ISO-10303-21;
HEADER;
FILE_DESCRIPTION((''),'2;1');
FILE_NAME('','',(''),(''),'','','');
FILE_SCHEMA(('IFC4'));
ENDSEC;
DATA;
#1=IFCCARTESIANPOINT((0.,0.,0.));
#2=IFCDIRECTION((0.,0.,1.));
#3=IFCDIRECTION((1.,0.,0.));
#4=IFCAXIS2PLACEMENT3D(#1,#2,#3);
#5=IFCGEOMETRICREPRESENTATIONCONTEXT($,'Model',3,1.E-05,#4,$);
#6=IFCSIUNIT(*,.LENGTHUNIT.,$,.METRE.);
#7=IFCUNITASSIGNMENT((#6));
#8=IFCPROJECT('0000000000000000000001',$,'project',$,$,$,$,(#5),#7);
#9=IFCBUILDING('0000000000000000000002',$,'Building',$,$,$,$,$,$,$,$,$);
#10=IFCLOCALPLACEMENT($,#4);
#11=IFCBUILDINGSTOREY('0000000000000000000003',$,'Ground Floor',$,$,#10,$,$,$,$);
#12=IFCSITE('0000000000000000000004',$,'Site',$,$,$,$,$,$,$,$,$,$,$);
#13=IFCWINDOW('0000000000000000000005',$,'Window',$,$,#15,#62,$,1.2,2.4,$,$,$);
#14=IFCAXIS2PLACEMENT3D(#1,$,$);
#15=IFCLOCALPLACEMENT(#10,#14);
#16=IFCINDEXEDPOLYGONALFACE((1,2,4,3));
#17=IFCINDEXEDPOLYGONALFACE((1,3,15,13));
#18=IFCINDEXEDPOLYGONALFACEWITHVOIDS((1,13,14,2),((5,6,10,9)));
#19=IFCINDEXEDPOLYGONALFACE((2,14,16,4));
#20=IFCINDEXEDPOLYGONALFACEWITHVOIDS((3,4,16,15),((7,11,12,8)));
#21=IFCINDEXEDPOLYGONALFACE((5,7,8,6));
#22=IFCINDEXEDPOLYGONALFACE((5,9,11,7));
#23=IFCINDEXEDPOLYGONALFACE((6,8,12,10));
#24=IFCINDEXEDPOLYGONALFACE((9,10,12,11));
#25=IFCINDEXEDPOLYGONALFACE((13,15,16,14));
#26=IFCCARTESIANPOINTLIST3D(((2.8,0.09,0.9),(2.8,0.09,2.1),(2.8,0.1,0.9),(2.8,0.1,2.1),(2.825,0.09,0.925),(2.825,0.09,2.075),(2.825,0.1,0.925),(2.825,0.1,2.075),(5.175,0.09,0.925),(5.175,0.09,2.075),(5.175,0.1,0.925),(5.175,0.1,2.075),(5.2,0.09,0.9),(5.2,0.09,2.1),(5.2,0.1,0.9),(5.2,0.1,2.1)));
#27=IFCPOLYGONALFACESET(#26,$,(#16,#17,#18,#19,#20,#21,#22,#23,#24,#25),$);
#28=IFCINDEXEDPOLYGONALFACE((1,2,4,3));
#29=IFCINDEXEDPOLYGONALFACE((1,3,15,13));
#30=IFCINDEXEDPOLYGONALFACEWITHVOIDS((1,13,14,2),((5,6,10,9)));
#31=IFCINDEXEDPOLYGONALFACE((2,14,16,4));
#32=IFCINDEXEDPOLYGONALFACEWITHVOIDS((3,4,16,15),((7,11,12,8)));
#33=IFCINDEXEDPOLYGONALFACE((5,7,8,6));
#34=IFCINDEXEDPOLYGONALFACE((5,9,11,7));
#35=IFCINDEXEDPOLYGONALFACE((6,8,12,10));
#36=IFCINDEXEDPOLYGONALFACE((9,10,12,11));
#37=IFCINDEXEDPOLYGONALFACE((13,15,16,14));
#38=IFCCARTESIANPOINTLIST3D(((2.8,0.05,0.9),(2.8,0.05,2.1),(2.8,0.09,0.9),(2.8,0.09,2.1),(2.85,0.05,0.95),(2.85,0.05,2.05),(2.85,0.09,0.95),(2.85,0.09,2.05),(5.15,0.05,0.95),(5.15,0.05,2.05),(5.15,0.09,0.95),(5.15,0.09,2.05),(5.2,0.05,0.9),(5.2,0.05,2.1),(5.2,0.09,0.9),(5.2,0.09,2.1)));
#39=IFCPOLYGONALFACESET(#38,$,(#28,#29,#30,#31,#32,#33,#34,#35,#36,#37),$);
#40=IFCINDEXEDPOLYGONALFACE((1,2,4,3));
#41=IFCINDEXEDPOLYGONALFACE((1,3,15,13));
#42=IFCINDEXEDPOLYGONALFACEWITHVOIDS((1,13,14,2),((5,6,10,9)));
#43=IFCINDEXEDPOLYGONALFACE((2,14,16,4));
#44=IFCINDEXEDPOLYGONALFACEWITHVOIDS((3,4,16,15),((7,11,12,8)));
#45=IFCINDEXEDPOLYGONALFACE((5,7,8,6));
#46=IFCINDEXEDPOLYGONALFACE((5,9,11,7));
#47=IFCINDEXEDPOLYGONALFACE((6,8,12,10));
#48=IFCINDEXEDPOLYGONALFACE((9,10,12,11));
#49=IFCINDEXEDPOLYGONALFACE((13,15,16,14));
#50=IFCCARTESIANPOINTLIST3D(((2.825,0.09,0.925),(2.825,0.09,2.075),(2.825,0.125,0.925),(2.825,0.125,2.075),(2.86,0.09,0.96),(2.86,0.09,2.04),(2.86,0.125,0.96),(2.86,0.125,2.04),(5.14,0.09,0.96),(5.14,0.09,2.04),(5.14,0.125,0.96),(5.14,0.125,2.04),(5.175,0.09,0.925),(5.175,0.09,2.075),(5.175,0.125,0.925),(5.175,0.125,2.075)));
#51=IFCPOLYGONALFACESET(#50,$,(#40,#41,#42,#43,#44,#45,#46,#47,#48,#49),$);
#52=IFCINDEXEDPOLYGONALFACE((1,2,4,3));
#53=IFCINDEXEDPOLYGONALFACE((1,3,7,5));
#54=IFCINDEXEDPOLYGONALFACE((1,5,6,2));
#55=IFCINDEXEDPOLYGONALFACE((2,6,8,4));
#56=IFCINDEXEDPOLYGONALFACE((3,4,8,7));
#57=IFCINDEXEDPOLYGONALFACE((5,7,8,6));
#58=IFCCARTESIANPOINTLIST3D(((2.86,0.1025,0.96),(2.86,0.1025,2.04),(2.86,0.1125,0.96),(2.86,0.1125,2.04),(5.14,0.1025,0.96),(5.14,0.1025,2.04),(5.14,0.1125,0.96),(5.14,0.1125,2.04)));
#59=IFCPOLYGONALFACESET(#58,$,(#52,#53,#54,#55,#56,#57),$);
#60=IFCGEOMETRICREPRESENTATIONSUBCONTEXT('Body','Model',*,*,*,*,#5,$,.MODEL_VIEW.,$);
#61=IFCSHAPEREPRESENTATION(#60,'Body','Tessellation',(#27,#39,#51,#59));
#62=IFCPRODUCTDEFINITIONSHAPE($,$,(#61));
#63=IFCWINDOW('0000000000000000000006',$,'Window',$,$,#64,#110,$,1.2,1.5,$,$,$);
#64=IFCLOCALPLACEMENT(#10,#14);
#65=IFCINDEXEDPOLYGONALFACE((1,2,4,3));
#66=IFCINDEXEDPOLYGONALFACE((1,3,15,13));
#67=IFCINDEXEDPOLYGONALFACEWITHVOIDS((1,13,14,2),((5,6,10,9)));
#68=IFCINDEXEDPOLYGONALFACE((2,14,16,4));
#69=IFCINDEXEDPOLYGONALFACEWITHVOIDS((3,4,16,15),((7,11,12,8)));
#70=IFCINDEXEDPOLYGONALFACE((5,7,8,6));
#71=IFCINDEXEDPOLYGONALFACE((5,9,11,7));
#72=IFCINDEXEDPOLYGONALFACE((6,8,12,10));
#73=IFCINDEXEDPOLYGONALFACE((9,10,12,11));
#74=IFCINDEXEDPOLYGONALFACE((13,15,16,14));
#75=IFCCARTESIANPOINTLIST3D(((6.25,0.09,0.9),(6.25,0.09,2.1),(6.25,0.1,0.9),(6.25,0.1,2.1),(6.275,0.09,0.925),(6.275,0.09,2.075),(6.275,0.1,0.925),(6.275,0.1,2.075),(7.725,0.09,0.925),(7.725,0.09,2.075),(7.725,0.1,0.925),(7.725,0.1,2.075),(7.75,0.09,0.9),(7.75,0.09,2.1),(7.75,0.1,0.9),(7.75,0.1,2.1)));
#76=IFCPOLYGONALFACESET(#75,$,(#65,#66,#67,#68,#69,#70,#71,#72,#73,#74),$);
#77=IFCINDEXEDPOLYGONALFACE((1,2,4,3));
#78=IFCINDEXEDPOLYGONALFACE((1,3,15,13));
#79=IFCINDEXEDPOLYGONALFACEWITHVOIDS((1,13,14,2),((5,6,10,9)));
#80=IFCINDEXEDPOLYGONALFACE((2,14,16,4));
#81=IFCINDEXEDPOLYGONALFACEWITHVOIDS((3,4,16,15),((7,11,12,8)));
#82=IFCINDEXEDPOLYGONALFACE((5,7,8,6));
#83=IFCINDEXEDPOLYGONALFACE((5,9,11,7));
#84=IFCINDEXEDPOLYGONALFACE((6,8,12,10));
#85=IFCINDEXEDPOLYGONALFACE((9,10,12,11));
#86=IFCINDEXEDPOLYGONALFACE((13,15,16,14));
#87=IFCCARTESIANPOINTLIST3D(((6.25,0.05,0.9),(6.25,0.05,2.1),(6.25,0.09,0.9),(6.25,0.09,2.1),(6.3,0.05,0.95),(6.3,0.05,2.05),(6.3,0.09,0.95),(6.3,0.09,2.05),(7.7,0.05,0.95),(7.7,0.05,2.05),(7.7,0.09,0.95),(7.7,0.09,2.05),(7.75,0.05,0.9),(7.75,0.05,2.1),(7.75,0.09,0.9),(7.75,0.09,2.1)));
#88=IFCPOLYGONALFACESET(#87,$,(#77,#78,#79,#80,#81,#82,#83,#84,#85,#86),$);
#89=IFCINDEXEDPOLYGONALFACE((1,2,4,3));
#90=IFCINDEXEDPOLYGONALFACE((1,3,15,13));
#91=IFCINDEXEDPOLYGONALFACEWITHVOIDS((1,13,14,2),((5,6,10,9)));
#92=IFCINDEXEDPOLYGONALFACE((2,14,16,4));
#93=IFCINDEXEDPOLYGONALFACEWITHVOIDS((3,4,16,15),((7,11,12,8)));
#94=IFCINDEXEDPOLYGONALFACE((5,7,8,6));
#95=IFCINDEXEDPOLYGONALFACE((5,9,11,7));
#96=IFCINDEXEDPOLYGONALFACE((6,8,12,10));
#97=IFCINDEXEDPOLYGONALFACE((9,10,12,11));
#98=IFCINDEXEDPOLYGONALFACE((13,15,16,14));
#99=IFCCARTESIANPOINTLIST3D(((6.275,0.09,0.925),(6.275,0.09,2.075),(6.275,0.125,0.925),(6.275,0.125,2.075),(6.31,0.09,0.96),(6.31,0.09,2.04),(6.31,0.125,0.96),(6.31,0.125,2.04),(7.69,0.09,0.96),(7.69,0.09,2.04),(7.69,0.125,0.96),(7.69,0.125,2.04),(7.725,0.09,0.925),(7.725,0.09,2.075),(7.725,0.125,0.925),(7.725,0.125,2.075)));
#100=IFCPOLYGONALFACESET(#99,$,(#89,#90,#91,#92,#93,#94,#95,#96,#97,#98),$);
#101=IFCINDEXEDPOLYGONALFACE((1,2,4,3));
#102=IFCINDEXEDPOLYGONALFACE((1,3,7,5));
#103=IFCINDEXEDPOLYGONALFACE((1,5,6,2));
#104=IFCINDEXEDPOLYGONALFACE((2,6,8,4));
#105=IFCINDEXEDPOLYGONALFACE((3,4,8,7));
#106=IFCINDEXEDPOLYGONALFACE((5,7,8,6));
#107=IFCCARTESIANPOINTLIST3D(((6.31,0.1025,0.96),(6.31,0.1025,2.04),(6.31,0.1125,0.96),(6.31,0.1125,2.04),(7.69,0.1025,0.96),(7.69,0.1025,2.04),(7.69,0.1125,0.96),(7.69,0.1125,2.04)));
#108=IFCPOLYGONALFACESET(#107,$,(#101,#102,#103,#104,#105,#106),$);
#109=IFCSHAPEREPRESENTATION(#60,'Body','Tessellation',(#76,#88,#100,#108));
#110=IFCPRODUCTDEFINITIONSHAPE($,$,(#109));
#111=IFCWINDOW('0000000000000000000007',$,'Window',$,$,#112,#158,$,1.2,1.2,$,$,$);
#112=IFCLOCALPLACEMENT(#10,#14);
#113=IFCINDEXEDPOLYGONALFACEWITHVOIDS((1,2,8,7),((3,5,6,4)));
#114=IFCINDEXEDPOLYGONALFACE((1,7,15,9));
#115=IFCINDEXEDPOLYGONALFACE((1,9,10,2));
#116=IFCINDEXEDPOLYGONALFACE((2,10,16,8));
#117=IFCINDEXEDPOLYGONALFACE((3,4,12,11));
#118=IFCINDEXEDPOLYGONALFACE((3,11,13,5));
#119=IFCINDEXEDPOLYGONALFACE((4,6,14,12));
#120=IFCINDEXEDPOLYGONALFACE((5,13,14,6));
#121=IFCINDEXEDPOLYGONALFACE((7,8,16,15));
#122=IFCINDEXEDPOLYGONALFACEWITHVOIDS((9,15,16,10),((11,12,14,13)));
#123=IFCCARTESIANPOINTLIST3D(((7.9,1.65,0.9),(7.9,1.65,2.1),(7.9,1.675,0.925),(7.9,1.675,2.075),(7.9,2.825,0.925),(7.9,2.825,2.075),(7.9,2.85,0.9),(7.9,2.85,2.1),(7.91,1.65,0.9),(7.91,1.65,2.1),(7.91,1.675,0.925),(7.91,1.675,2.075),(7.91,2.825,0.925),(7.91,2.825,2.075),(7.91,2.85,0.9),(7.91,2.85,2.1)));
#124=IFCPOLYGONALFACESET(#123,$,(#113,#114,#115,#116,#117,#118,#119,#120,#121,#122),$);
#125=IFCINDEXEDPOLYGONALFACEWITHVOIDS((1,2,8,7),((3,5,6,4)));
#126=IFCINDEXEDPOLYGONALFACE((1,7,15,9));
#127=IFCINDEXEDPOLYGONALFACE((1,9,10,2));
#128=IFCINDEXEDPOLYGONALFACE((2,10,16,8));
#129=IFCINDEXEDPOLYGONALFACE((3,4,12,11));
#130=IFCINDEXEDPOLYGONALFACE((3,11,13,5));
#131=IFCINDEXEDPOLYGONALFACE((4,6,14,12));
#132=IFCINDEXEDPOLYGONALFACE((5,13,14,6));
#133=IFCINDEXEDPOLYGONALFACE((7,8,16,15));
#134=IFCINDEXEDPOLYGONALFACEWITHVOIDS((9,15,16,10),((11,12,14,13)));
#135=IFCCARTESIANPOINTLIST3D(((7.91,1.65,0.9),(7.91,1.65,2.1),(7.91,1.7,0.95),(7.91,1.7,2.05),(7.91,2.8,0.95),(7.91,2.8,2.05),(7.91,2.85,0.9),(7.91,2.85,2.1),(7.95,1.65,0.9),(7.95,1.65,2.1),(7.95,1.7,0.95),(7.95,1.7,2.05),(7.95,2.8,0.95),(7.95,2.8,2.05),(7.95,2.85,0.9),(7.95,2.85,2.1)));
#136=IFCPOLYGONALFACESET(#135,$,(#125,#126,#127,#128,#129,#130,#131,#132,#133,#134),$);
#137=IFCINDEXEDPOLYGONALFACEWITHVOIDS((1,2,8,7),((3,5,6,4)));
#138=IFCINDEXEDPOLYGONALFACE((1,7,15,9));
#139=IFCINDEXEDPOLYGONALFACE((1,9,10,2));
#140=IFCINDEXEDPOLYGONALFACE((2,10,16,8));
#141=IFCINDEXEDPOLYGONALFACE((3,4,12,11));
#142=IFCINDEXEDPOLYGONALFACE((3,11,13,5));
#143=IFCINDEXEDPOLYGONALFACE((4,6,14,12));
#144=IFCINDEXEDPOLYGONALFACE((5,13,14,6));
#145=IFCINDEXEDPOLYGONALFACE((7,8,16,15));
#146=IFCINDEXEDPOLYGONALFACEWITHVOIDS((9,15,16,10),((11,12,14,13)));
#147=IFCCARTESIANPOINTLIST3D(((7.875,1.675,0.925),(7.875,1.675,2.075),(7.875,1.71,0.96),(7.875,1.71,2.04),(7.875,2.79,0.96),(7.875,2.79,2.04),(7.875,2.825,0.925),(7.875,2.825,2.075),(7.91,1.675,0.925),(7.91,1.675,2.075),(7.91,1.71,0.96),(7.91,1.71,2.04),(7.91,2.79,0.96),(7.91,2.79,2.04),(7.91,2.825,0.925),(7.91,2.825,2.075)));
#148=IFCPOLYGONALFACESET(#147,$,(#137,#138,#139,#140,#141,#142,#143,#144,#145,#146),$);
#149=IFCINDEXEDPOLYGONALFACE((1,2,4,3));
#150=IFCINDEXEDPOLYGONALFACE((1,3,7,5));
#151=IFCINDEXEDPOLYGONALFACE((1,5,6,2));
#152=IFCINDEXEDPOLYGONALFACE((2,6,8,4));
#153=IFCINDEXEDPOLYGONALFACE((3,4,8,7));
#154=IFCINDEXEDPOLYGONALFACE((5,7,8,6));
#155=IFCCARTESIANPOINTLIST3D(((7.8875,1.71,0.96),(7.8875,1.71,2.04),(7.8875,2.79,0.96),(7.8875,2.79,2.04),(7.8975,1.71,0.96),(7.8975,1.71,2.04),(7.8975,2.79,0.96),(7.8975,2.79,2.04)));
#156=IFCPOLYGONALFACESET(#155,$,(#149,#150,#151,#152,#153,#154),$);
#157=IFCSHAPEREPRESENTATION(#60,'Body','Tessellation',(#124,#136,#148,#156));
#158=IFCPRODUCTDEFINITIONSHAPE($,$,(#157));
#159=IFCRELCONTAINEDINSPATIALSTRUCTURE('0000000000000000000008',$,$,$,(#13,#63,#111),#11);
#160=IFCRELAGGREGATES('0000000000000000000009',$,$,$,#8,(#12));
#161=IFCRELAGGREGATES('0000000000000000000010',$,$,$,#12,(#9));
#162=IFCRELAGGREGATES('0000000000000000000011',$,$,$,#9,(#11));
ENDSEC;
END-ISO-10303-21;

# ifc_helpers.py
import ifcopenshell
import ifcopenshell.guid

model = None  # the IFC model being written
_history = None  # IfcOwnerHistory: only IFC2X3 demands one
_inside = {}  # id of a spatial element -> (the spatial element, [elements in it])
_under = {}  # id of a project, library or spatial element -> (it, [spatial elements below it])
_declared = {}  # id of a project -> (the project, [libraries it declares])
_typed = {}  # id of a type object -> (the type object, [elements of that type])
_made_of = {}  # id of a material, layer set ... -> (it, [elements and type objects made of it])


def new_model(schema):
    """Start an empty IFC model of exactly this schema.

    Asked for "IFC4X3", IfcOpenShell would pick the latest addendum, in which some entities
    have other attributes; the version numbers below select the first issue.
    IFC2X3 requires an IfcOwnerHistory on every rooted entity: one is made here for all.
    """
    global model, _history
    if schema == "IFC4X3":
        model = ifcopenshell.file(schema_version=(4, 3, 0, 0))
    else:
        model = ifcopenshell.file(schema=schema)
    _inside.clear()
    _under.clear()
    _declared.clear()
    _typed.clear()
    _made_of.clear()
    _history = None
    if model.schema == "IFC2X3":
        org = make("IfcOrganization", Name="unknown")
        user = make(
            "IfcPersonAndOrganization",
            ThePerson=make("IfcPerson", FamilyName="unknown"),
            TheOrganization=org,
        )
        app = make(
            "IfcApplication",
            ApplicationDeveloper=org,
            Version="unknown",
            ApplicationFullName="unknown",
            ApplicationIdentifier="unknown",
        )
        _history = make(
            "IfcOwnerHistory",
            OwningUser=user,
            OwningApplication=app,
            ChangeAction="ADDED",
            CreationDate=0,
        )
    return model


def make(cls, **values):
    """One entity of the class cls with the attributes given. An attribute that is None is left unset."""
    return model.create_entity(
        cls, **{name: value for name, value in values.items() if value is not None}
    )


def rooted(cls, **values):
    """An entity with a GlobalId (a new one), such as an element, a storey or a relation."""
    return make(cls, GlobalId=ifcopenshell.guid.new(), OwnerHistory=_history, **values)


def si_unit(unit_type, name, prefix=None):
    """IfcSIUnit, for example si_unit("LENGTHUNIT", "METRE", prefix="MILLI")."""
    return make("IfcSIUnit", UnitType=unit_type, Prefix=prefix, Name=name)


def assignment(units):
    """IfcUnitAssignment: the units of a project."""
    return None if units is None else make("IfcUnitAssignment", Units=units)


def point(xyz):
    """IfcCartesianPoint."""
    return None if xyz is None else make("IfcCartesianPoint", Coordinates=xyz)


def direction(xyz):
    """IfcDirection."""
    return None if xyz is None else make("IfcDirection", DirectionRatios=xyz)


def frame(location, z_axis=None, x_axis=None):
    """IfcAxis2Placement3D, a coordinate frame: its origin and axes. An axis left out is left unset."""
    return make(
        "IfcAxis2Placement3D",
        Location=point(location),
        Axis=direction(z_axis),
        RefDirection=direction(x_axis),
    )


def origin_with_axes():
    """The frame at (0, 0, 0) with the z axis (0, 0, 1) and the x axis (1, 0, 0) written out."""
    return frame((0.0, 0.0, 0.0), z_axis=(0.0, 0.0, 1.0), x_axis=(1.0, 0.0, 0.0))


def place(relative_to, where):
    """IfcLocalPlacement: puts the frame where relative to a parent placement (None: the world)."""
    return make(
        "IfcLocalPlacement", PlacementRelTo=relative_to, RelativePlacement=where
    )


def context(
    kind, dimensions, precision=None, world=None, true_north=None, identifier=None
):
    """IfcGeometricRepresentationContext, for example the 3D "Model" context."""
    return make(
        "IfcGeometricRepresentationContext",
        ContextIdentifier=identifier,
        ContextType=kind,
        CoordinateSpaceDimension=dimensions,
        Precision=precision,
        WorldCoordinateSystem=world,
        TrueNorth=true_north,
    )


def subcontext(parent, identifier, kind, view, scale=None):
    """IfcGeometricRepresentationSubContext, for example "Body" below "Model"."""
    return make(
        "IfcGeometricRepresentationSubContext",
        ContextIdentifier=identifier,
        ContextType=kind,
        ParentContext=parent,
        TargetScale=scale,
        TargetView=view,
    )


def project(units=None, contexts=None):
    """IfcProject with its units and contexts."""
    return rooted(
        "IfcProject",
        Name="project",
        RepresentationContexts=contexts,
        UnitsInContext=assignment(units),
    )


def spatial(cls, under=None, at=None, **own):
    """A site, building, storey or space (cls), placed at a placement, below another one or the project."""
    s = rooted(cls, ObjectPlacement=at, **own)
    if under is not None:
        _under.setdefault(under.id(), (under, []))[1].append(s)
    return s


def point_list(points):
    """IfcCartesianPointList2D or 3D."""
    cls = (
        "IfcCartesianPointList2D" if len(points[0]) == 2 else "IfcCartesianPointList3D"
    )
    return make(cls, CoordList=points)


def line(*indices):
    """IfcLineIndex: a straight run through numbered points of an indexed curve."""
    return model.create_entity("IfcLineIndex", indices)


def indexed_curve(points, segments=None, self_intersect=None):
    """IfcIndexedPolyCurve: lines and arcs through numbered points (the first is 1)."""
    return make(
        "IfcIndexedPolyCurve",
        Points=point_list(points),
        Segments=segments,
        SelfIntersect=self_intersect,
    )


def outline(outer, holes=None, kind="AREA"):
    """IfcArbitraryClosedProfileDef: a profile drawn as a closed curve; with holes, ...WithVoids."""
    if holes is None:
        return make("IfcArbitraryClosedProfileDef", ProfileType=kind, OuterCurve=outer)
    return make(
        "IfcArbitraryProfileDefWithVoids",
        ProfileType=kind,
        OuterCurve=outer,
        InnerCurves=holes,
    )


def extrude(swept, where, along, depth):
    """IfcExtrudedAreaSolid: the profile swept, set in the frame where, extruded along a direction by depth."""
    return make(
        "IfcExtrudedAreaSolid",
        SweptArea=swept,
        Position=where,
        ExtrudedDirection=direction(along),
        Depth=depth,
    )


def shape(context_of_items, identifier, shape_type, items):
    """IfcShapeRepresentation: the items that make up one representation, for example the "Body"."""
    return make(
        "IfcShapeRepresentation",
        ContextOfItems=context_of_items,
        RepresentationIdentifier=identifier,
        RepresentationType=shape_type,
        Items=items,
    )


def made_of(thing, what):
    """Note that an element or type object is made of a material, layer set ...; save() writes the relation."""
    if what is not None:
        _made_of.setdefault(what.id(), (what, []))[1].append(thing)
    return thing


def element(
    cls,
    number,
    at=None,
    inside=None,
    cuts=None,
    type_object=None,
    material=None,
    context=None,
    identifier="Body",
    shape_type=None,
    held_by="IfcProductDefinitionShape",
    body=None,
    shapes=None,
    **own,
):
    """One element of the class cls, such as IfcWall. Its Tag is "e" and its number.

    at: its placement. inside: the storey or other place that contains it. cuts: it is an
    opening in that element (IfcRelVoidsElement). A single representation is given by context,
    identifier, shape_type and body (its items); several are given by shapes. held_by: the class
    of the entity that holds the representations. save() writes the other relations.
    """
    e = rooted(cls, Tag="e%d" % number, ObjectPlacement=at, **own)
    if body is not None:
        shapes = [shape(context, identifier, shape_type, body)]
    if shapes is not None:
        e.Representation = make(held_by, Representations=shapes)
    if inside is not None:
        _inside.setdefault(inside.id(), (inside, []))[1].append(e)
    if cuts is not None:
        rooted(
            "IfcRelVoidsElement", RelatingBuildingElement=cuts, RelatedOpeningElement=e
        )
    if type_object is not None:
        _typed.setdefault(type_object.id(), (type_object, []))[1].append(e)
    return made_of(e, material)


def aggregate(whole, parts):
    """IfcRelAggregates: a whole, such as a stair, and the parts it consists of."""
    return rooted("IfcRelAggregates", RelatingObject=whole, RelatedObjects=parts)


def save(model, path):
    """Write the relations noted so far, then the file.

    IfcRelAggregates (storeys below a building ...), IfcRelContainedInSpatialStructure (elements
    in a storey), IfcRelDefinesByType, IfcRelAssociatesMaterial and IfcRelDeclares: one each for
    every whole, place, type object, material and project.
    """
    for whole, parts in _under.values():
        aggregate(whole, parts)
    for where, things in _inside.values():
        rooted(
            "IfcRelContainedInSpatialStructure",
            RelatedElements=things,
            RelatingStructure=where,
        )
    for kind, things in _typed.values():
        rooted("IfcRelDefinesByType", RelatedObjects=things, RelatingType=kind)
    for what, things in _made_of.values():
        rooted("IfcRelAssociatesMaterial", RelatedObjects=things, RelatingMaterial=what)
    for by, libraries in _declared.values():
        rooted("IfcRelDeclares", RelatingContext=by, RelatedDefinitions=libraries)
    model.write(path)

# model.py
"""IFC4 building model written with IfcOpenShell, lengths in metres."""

from ifc_helpers import new_model, si_unit, frame, origin_with_axes, place, context, subcontext, project, spatial, line, indexed_curve, outline, extrude, element, save


model = new_model("IFC4")

# Units and contexts
model_context = context("Model", 3, precision=1e-05, world=origin_with_axes())
body_context = subcontext(model_context, "Body", "Model", "MODEL_VIEW")
ifc_project = project(units=[si_unit("LENGTHUNIT", "METRE")], contexts=[model_context])

# Site, building, storey
site = spatial("IfcSite", under=ifc_project, Name="Site")
building = spatial("IfcBuilding", under=site, Name="Building")
storey_placement = place(None, origin_with_axes())
storey = spatial("IfcBuildingStorey", under=building, at=storey_placement, Name="Ground Floor")

# Windows
window_1_placement = place(storey_placement, frame((2.8, 0.0, 0.9), z_axis=(0.0, 0.0, 1.0), x_axis=(1.0, 0.0, 0.0)))
element("IfcWindow", 1, at=window_1_placement, inside=storey, Name="Window", OverallHeight=1.2, OverallWidth=2.4, context=body_context, shape_type="SweptSolid", body=[
    extrude(outline(indexed_curve([(0.0, 0.0), (2.4, 0.0), (2.4, 1.2), (0.0, 1.2)], segments=[line(1, 2, 3, 4, 1)]), holes=[indexed_curve([(0.025, 0.025), (2.375, 0.025), (2.375, 1.175), (0.025, 1.175)], segments=[line(1, 2, 3, 4, 1)])]), frame((0.0, 0.09, 0.0), z_axis=(0.0, -1.0, 0.0), x_axis=(1.0, 0.0, 0.0)), (0.0, 0.0, -1.0), 0.01),
    extrude(outline(indexed_curve([(0.0, 0.0), (2.4, 0.0), (2.4, 1.2), (0.0, 1.2)], segments=[line(1, 2, 3, 4, 1)]), holes=[indexed_curve([(0.05, 0.05), (2.35, 0.05), (2.35, 1.15), (0.05, 1.15)], segments=[line(1, 2, 3, 4, 1)])]), frame((0.0, 0.05, 0.0), z_axis=(0.0, -1.0, 0.0), x_axis=(1.0, 0.0, 0.0)), (0.0, 0.0, -1.0), 0.04),
    extrude(outline(indexed_curve([(0.0, 0.0), (2.35, 0.0), (2.35, 1.15), (0.0, 1.15)], segments=[line(1, 2, 3, 4, 1)]), holes=[indexed_curve([(0.035, 0.035), (2.315, 0.035), (2.315, 1.115), (0.035, 1.115)], segments=[line(1, 2, 3, 4, 1)])]), frame((0.025, 0.09, 0.025), z_axis=(0.0, -1.0, 0.0), x_axis=(1.0, 0.0, 0.0)), (0.0, 0.0, -1.0), 0.035),
    extrude(outline(indexed_curve([(0.035, 0.035), (2.315, 0.035), (2.315, 1.115), (0.035, 1.115)], segments=[line(1, 2, 3, 4, 1)])), frame((0.025, 0.1025, 0.025), z_axis=(0.0, -1.0, 0.0), x_axis=(1.0, 0.0, 0.0)), (0.0, 0.0, -1.0), 0.01),
])
window_2_placement = place(storey_placement, frame((6.25, 0.0, 0.9), z_axis=(0.0, 0.0, 1.0), x_axis=(1.0, 0.0, 0.0)))
element("IfcWindow", 2, at=window_2_placement, inside=storey, Name="Window", OverallHeight=1.2, OverallWidth=1.5, context=body_context, shape_type="SweptSolid", body=[
    extrude(outline(indexed_curve([(0.0, 0.0), (1.5, 0.0), (1.5, 1.2), (0.0, 1.2)], segments=[line(1, 2, 3, 4, 1)]), holes=[indexed_curve([(0.025, 0.025), (1.475, 0.025), (1.475, 1.175), (0.025, 1.175)], segments=[line(1, 2, 3, 4, 1)])]), frame((0.0, 0.09, 0.0), z_axis=(0.0, -1.0, 0.0), x_axis=(1.0, 0.0, 0.0)), (0.0, 0.0, -1.0), 0.01),
    extrude(outline(indexed_curve([(0.0, 0.0), (1.5, 0.0), (1.5, 1.2), (0.0, 1.2)], segments=[line(1, 2, 3, 4, 1)]), holes=[indexed_curve([(0.05, 0.05), (1.45, 0.05), (1.45, 1.15), (0.05, 1.15)], segments=[line(1, 2, 3, 4, 1)])]), frame((0.0, 0.05, 0.0), z_axis=(0.0, -1.0, 0.0), x_axis=(1.0, 0.0, 0.0)), (0.0, 0.0, -1.0), 0.04),
    extrude(outline(indexed_curve([(0.0, 0.0), (1.45, 0.0), (1.45, 1.15), (0.0, 1.15)], segments=[line(1, 2, 3, 4, 1)]), holes=[indexed_curve([(0.035, 0.035), (1.415, 0.035), (1.415, 1.115), (0.035, 1.115)], segments=[line(1, 2, 3, 4, 1)])]), frame((0.025, 0.09, 0.025), z_axis=(0.0, -1.0, 0.0), x_axis=(1.0, 0.0, 0.0)), (0.0, 0.0, -1.0), 0.035),
    extrude(outline(indexed_curve([(0.035, 0.035), (1.415, 0.035), (1.415, 1.115), (0.035, 1.115)], segments=[line(1, 2, 3, 4, 1)])), frame((0.025, 0.1025, 0.025), z_axis=(0.0, -1.0, 0.0), x_axis=(1.0, 0.0, 0.0)), (0.0, 0.0, -1.0), 0.01),
])
window_3_placement = place(storey_placement, frame((8.0, 1.65, 0.9), z_axis=(0.0, 0.0, 1.0), x_axis=(0.0, 1.0, 0.0)))
element("IfcWindow", 3, at=window_3_placement, inside=storey, Name="Window", OverallHeight=1.2, OverallWidth=1.2, context=body_context, shape_type="SweptSolid", body=[
    extrude(outline(indexed_curve([(0.0, 0.0), (1.2, 0.0), (1.2, 1.2), (0.0, 1.2)], segments=[line(1, 2, 3, 4, 1)]), holes=[indexed_curve([(0.025, 0.025), (1.175, 0.025), (1.175, 1.175), (0.025, 1.175)], segments=[line(1, 2, 3, 4, 1)])]), frame((0.0, 0.09, 0.0), z_axis=(0.0, -1.0, 0.0), x_axis=(1.0, 0.0, 0.0)), (0.0, 0.0, -1.0), 0.01),
    extrude(outline(indexed_curve([(0.0, 0.0), (1.2, 0.0), (1.2, 1.2), (0.0, 1.2)], segments=[line(1, 2, 3, 4, 1)]), holes=[indexed_curve([(0.05, 0.05), (1.15, 0.05), (1.15, 1.15), (0.05, 1.15)], segments=[line(1, 2, 3, 4, 1)])]), frame((0.0, 0.05, 0.0), z_axis=(0.0, -1.0, 0.0), x_axis=(1.0, 0.0, 0.0)), (0.0, 0.0, -1.0), 0.04),
    extrude(outline(indexed_curve([(0.0, 0.0), (1.15, 0.0), (1.15, 1.15), (0.0, 1.15)], segments=[line(1, 2, 3, 4, 1)]), holes=[indexed_curve([(0.035, 0.035), (1.115, 0.035), (1.115, 1.115), (0.035, 1.115)], segments=[line(1, 2, 3, 4, 1)])]), frame((0.025, 0.09, 0.025), z_axis=(0.0, -1.0, 0.0), x_axis=(1.0, 0.0, 0.0)), (0.0, 0.0, -1.0), 0.035),
    extrude(outline(indexed_curve([(0.035, 0.035), (1.115, 0.035), (1.115, 1.115), (0.035, 1.115)], segments=[line(1, 2, 3, 4, 1)])), frame((0.025, 0.1025, 0.025), z_axis=(0.0, -1.0, 0.0), x_axis=(1.0, 0.0, 0.0)), (0.0, 0.0, -1.0), 0.01),
])

save(model, "model.ifc")
